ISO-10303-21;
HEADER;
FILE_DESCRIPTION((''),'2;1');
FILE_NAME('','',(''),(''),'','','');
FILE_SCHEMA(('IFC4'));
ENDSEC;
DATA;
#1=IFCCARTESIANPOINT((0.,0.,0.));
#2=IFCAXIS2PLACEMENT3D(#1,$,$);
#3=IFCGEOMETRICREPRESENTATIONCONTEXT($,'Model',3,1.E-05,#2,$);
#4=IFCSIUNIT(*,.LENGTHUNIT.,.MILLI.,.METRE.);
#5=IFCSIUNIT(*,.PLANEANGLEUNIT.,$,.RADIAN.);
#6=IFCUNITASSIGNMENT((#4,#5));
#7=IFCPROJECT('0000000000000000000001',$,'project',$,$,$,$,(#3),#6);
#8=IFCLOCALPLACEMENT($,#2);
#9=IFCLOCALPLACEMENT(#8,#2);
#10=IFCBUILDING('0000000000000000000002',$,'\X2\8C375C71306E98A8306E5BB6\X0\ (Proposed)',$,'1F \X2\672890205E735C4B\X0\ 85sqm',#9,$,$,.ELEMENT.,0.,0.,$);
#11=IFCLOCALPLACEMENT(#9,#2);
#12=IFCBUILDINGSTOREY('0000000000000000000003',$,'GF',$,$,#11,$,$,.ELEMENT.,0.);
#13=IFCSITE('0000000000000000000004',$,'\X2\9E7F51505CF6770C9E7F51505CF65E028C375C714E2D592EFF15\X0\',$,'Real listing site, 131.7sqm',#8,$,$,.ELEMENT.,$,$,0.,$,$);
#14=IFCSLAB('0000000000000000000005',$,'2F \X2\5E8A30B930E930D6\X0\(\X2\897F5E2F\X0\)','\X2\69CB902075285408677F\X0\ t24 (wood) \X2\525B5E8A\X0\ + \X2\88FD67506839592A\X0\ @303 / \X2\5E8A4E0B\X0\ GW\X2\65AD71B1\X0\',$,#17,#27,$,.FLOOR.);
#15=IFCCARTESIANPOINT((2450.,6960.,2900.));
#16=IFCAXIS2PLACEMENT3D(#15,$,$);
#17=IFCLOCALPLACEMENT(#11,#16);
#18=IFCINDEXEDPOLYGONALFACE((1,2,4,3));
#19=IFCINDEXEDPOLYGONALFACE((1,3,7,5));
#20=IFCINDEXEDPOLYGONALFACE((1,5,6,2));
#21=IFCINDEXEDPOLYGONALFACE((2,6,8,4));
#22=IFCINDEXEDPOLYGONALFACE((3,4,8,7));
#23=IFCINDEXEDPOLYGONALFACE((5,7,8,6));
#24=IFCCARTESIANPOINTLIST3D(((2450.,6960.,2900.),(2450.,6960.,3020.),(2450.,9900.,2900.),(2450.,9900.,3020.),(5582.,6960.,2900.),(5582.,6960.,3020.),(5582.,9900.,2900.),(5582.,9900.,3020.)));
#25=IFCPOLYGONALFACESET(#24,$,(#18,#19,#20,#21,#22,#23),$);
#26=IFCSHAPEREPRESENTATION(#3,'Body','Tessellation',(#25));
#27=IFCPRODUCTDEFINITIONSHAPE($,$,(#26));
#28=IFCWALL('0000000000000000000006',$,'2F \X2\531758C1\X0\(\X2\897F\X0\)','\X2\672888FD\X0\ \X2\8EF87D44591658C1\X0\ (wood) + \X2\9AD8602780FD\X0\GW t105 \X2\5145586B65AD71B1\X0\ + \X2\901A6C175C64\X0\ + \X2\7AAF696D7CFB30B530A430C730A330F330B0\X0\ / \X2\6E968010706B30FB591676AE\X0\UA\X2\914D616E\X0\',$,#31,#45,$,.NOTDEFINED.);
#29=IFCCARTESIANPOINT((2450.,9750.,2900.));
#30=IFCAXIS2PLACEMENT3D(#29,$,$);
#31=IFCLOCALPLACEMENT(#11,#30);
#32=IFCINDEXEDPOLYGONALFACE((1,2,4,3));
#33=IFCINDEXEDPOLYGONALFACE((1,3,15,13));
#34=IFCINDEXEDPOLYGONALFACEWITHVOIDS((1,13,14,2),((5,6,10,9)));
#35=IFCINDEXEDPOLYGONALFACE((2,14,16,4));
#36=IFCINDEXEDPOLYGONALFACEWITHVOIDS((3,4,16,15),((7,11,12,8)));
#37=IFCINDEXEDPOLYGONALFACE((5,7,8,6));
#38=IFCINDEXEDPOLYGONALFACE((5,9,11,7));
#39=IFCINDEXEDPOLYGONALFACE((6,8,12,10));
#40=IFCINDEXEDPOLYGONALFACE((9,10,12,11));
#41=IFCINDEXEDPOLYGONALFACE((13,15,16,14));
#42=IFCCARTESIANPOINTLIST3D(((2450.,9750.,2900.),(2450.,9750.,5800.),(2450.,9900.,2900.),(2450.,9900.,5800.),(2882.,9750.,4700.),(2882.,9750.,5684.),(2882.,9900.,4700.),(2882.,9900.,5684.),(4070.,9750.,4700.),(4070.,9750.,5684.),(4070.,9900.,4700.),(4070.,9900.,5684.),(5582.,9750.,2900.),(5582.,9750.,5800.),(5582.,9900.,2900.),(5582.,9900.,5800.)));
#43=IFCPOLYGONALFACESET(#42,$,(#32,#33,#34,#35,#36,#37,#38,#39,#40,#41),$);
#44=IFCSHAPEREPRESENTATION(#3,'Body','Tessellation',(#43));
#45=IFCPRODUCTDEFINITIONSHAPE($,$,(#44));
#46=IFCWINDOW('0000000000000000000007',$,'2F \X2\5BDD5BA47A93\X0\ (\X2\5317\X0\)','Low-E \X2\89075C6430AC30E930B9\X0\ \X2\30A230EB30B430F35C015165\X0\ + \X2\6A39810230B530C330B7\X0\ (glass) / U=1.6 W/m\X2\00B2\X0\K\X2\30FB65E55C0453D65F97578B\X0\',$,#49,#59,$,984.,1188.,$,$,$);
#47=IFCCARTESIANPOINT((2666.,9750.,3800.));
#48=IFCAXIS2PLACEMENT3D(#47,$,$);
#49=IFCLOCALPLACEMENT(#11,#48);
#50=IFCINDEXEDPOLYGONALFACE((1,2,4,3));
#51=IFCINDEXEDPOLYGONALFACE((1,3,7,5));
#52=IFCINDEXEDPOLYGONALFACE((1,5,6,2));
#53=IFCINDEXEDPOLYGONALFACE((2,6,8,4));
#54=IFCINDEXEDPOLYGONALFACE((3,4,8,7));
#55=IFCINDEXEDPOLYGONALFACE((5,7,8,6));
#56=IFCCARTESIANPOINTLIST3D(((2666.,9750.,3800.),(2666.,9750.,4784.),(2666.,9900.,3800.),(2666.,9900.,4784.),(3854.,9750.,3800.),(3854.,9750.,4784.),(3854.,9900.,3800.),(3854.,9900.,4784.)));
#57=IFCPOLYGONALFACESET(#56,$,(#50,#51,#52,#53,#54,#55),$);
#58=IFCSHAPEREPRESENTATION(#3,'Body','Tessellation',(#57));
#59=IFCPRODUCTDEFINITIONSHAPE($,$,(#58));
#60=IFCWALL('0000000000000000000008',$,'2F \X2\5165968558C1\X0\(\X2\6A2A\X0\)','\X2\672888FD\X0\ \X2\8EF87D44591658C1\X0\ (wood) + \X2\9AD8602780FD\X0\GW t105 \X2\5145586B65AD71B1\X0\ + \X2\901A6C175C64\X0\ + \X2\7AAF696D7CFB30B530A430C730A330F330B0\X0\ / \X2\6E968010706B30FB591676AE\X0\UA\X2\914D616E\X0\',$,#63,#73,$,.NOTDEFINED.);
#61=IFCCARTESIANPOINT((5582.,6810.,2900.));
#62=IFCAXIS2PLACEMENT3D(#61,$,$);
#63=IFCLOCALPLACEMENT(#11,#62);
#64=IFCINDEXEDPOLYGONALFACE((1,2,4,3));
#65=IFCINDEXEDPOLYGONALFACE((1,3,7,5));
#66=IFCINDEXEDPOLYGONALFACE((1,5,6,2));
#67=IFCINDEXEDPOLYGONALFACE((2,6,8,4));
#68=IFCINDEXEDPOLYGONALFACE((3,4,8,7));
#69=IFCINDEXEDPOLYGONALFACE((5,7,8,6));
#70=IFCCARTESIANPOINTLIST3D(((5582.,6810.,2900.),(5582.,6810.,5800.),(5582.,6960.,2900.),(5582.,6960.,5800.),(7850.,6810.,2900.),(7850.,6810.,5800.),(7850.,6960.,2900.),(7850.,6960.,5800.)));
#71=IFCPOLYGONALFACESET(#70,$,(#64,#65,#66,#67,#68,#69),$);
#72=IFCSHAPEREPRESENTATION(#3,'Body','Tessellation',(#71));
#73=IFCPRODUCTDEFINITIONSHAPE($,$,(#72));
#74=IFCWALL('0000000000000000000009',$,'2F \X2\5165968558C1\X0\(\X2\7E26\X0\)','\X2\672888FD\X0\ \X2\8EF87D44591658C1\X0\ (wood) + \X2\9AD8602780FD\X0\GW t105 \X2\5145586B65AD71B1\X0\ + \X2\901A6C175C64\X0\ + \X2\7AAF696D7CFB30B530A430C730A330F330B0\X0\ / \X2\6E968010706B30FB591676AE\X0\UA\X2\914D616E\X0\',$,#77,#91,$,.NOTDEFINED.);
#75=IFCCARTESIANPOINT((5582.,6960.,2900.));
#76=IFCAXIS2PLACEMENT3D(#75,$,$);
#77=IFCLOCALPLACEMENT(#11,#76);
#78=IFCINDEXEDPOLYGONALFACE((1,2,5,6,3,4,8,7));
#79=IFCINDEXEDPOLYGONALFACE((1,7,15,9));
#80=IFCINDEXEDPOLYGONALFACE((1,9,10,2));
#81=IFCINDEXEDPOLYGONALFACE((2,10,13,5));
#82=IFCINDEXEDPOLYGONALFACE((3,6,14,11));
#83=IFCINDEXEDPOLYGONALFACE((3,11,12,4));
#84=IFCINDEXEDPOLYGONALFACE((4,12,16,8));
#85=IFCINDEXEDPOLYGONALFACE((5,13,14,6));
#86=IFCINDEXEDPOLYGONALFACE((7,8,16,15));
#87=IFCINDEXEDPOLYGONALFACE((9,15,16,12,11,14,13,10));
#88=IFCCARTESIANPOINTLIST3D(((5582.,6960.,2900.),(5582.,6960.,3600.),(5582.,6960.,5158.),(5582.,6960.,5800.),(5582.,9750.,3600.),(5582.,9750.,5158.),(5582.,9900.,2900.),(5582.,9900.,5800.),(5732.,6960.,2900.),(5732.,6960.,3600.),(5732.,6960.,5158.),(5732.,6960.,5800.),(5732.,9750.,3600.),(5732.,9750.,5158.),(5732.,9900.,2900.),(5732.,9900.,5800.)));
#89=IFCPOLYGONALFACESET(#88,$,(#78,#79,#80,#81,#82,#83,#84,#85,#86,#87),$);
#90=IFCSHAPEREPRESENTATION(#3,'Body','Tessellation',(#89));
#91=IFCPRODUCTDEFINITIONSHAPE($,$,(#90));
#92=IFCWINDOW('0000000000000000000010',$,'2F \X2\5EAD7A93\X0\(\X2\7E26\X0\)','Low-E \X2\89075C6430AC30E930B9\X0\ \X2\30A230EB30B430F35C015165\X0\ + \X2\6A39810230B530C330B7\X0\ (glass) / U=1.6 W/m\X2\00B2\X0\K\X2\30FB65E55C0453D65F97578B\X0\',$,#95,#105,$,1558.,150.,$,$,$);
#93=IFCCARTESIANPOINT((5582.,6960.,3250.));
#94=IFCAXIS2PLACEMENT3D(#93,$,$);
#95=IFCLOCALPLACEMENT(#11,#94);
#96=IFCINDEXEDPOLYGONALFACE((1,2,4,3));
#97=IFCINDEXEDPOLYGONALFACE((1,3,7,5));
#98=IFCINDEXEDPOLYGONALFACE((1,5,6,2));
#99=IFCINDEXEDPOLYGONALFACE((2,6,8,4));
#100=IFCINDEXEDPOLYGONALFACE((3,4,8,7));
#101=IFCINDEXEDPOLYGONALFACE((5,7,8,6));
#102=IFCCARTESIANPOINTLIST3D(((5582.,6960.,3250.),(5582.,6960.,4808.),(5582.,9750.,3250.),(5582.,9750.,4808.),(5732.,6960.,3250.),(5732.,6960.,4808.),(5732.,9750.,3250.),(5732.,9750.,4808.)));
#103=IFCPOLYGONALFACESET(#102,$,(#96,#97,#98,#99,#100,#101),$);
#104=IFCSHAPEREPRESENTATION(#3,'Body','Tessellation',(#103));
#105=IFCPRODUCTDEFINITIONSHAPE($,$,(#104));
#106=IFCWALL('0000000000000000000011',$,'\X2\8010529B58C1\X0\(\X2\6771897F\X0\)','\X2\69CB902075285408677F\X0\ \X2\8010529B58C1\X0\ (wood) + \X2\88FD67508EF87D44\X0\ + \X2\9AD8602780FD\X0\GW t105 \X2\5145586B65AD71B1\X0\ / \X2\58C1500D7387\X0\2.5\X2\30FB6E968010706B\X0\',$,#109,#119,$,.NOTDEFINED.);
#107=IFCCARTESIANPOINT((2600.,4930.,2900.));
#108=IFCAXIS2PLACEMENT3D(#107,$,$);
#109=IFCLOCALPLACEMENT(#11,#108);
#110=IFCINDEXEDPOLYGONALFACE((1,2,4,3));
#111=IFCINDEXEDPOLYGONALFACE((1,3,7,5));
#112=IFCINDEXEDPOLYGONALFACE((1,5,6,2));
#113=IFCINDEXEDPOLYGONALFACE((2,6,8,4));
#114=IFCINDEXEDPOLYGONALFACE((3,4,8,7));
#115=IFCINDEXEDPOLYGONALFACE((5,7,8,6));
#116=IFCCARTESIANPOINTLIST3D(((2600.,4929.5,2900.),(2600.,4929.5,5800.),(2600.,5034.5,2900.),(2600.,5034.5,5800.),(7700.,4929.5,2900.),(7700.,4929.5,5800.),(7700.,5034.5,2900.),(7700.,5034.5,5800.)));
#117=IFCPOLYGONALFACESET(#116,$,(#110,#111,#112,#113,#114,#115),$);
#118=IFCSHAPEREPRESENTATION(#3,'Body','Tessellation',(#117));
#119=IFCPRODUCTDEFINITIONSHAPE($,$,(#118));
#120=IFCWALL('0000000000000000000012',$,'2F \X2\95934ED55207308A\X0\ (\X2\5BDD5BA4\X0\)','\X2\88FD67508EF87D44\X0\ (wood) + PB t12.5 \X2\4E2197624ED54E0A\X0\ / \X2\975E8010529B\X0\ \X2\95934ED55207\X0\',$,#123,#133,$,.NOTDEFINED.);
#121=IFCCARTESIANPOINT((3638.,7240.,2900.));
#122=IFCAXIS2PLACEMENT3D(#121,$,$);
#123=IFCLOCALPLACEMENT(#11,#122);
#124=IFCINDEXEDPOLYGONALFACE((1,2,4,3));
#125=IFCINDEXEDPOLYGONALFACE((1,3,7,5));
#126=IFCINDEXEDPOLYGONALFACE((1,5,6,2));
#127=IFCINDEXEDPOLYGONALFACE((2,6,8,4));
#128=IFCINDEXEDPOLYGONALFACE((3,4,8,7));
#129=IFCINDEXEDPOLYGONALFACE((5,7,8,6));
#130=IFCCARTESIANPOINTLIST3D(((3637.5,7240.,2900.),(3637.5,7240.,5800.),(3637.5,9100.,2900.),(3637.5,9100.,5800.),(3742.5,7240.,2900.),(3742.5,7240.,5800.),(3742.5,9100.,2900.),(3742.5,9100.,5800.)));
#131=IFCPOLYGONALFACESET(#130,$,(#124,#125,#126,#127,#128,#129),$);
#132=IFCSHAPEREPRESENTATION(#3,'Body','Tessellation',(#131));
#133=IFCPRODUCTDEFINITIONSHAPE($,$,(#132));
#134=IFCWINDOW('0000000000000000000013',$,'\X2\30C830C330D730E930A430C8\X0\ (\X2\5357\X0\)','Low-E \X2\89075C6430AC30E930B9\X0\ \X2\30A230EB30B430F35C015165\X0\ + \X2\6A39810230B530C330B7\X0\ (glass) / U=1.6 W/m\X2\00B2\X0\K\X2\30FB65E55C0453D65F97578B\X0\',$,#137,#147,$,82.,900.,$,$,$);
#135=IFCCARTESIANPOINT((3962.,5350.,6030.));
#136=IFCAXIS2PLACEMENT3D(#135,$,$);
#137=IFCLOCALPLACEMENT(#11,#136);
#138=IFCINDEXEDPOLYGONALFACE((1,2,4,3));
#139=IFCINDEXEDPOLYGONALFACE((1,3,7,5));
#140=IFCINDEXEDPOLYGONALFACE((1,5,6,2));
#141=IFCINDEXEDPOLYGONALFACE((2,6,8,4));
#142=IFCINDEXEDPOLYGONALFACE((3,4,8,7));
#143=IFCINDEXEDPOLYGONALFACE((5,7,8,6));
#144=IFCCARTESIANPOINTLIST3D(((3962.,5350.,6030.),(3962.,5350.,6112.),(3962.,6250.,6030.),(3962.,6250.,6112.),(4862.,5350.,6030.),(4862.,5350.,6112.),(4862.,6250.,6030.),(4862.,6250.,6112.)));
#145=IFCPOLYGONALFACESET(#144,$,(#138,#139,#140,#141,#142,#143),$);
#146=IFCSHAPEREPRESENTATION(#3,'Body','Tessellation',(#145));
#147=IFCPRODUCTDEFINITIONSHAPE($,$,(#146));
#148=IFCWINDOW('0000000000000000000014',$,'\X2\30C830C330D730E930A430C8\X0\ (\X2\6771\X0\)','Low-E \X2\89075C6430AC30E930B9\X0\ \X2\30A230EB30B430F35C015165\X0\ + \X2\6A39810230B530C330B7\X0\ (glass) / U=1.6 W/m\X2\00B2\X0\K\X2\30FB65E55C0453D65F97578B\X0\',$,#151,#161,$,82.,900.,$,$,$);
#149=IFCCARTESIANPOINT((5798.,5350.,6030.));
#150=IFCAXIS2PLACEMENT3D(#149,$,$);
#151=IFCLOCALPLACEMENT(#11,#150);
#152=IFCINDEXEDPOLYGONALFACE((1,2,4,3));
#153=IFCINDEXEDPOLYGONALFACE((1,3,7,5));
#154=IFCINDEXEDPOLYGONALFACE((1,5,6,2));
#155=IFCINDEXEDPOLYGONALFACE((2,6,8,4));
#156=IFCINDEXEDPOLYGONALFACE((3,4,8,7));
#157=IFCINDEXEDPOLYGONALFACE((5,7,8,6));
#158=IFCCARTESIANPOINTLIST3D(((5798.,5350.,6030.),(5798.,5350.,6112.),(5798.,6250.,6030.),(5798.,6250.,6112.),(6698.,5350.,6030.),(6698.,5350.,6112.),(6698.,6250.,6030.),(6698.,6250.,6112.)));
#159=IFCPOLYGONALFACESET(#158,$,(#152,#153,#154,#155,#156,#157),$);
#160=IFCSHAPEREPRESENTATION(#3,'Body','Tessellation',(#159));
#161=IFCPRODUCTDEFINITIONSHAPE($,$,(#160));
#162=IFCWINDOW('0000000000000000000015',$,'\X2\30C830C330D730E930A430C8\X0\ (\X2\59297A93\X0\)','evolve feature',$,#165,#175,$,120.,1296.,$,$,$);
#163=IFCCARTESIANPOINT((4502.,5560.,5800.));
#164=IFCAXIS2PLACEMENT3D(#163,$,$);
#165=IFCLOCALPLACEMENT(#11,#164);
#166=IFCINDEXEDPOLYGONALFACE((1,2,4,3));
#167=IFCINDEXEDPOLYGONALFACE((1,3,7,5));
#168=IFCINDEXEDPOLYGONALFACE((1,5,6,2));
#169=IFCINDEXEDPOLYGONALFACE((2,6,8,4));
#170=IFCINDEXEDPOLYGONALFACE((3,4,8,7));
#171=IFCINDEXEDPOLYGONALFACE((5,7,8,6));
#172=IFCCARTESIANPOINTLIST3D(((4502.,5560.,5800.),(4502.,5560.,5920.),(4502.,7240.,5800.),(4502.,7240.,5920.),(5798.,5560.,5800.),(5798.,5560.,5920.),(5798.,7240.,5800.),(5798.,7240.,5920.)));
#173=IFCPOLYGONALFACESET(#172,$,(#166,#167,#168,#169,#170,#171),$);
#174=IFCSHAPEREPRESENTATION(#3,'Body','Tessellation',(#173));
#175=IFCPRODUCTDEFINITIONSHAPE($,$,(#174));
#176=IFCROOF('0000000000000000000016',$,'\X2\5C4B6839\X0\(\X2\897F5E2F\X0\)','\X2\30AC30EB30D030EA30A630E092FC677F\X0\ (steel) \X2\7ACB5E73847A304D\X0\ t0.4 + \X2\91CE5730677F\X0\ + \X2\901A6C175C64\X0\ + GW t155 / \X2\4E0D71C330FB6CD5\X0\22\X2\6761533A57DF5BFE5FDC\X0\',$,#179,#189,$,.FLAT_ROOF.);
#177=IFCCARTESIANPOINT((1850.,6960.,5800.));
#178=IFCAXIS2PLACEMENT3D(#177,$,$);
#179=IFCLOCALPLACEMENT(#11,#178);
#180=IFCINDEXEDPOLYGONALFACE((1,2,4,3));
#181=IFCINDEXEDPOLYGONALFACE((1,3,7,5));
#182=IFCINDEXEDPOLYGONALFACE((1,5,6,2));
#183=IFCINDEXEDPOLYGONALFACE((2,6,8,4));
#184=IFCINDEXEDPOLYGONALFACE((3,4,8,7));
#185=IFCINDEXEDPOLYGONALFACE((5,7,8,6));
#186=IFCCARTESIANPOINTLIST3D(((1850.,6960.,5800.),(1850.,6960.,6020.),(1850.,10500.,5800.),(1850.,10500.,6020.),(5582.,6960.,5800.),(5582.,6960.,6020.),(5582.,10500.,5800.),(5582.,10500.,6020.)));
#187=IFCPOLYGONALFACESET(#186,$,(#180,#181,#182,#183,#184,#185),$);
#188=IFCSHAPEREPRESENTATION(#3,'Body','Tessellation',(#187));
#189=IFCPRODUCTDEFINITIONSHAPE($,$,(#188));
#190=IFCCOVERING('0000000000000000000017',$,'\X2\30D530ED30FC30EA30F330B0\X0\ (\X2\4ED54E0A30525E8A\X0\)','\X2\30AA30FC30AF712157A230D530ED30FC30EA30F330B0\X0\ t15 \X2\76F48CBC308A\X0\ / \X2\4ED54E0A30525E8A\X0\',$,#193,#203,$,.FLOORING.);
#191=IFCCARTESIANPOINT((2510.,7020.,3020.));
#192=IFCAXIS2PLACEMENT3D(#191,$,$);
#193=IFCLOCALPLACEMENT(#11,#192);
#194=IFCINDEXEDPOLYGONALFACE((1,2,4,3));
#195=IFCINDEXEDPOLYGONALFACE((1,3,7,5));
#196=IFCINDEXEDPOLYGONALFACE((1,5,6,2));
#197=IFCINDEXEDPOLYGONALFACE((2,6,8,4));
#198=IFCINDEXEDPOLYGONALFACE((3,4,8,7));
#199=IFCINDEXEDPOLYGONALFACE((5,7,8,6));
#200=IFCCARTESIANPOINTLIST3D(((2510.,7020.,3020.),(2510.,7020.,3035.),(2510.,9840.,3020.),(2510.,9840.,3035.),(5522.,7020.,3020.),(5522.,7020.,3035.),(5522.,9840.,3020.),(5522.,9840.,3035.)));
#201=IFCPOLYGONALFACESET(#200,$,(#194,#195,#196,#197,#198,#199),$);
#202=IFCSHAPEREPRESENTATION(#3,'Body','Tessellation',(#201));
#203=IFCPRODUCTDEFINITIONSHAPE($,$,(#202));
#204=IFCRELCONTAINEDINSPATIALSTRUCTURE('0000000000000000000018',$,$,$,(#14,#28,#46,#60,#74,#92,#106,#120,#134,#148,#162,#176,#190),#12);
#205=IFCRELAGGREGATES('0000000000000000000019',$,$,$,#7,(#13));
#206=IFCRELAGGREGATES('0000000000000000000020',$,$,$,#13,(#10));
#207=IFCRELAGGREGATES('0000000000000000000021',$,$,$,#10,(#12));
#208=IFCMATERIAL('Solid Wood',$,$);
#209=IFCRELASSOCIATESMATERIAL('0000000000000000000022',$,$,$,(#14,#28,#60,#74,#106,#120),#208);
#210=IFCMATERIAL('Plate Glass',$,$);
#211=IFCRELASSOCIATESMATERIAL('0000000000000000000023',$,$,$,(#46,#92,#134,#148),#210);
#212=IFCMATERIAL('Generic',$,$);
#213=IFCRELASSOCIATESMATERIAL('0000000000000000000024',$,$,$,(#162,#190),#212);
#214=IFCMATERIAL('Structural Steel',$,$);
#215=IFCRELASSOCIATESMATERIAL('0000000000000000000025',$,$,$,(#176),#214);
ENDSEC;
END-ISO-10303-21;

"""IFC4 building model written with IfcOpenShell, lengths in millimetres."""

from ifc_helpers import new_model, si_unit, frame, frame_2d, origin, place, context, project, spatial, rectangle, extrude, material, element, fill, save


model = new_model("IFC4")

# Units and contexts
model_context = context("Model", 3, precision=1e-05, world=origin())
ifc_project = project(units=[si_unit("LENGTHUNIT", "METRE", prefix="MILLI"), si_unit("PLANEANGLEUNIT", "RADIAN")], contexts=[model_context])

# Site, building, storey
site_placement = place(None, origin())
site = spatial("IfcSite", under=ifc_project, at=site_placement, Name="鹿児島県鹿児島市谷山中央５", ObjectType="Real listing site, 131.7sqm", CompositionType="ELEMENT", RefElevation=0.0)
building_placement = place(site_placement, origin())
building = spatial("IfcBuilding", under=site, at=building_placement, Name="谷山の風の家 (Proposed)", ObjectType="1F 木造平屋 85sqm", CompositionType="ELEMENT", ElevationOfRefHeight=0.0, ElevationOfTerrain=0.0)
storey_placement = place(building_placement, origin())
storey = spatial("IfcBuildingStorey", under=building, at=storey_placement, Name="GF", CompositionType="ELEMENT", Elevation=0.0)

# Slab
ifc_material_1 = material(Name="Solid Wood")
slab_placement = place(storey_placement, frame((2450.0, 6960.0, 2900.0)))
element("IfcSlab", 1, at=slab_placement, inside=storey, material=ifc_material_1, Name="2F 床スラブ(西帯)", Description="構造用合板 t24 (wood) 剛床 + 製材根太 @303 / 床下 GW断熱", PredefinedType="FLOOR", context=model_context, shape_type="SweptSolid", body=[
    extrude(rectangle(XDim=3132.0, YDim=2940.0, at=frame_2d((1566.0, 1470.0))), frame((2450.0, 6960.0, 2900.0)), (0.0, 0.0, 1.0), 120.0),
])

# Wall, opening, window
wall_1_placement = place(storey_placement, frame((2450.0, 9750.0, 2900.0)))
wall_1 = element("IfcWall", 2, at=wall_1_placement, inside=storey, material=ifc_material_1, Name="2F 北壁(西)", Description="木製 軸組外壁 (wood) + 高性能GW t105 充填断熱 + 通気層 + 窯業系サイディング / 準耐火・外皮UA配慮", PredefinedType="NOTDEFINED", context=model_context, shape_type="SweptSolid", body=[
    extrude(rectangle(XDim=3132.0, YDim=150.0, at=frame_2d((1566.0, 75.0))), frame((2450.0, 9750.0, 2900.0)), (0.0, 0.0, 1.0), 2900.0),
])
opening_1_placement = place(storey_placement, frame((2666.0, 9750.0, 3800.0)))
opening_1 = element("IfcOpeningElement", 3, at=opening_1_placement, cuts=wall_1, PredefinedType="NOTDEFINED", context=model_context, shape_type="SweptSolid", body=[
    extrude(rectangle(XDim=1188.0, YDim=150.0, at=frame_2d((594.0, 75.0))), frame((2666.0, 9750.0, 3800.0)), (0.0, 0.0, 1.0), 984.0),
])
ifc_material_2 = material(Name="Plate Glass")
window_1_placement = place(storey_placement, frame((2666.0, 9750.0, 3800.0)))
window_1 = element("IfcWindow", 4, at=window_1_placement, inside=storey, material=ifc_material_2, Name="2F 寝室窓 (北)", Description="Low-E 複層ガラス アルゴン封入 + 樹脂サッシ (glass) / U=1.6 W/m²K・日射取得型", OverallHeight=984.0, OverallWidth=1188.0, context=model_context, shape_type="SweptSolid", body=[
    extrude(rectangle(XDim=1188.0, YDim=150.0, at=frame_2d((594.0, 75.0))), frame((2666.0, 9750.0, 3800.0)), (0.0, 0.0, 1.0), 984.0),
])
fill(opening_1, window_1)

# Wall
wall_2_placement = place(storey_placement, frame((5582.0, 6810.0, 2900.0)))
element("IfcWall", 5, at=wall_2_placement, inside=storey, material=ifc_material_1, Name="2F 入隅壁(横)", Description="木製 軸組外壁 (wood) + 高性能GW t105 充填断熱 + 通気層 + 窯業系サイディング / 準耐火・外皮UA配慮", PredefinedType="NOTDEFINED", context=model_context, shape_type="SweptSolid", body=[
    extrude(rectangle(XDim=2268.0, YDim=150.0, at=frame_2d((1134.0, 75.0))), frame((5582.0, 6810.0, 2900.0)), (0.0, 0.0, 1.0), 2900.0),
])

# Wall, opening, window
wall_3_placement = place(storey_placement, frame((5582.0, 6960.0, 2900.0)))
wall_3 = element("IfcWall", 6, at=wall_3_placement, inside=storey, material=ifc_material_1, Name="2F 入隅壁(縦)", Description="木製 軸組外壁 (wood) + 高性能GW t105 充填断熱 + 通気層 + 窯業系サイディング / 準耐火・外皮UA配慮", PredefinedType="NOTDEFINED", context=model_context, shape_type="SweptSolid", body=[
    extrude(rectangle(XDim=150.0, YDim=2940.0, at=frame_2d((75.0, 1470.0))), frame((5582.0, 6960.0, 2900.0)), (0.0, 0.0, 1.0), 2900.0),
])
opening_2_placement = place(storey_placement, frame((5582.0, 6960.0, 3250.0)))
opening_2 = element("IfcOpeningElement", 7, at=opening_2_placement, cuts=wall_3, PredefinedType="NOTDEFINED", context=model_context, shape_type="SweptSolid", body=[
    extrude(rectangle(XDim=150.0, YDim=2790.0, at=frame_2d((75.0, 1395.0))), frame((5582.0, 6960.0, 3250.0)), (0.0, 0.0, 1.0), 1558.0),
])
window_2_placement = place(storey_placement, frame((5582.0, 6960.0, 3250.0)))
window_2 = element("IfcWindow", 8, at=window_2_placement, inside=storey, material=ifc_material_2, Name="2F 庭窓(縦)", Description="Low-E 複層ガラス アルゴン封入 + 樹脂サッシ (glass) / U=1.6 W/m²K・日射取得型", OverallHeight=1558.0, OverallWidth=150.0, context=model_context, shape_type="SweptSolid", body=[
    extrude(rectangle(XDim=150.0, YDim=2790.0, at=frame_2d((75.0, 1395.0))), frame((5582.0, 6960.0, 3250.0)), (0.0, 0.0, 1.0), 1558.0),
])
fill(opening_2, window_2)

# Walls
wall_4_placement = place(storey_placement, frame((2600.0, 4930.0, 2900.0)))
element("IfcWall", 9, at=wall_4_placement, inside=storey, material=ifc_material_1, Name="耐力壁(東西)", Description="構造用合板 耐力壁 (wood) + 製材軸組 + 高性能GW t105 充填断熱 / 壁倍率2.5・準耐火", PredefinedType="NOTDEFINED", context=model_context, shape_type="SweptSolid", body=[
    extrude(rectangle(XDim=5100.0, YDim=105.0, at=frame_2d((2550.0, 52.0))), frame((2600.0, 4930.0, 2900.0)), (0.0, 0.0, 1.0), 2900.0),
])
wall_5_placement = place(storey_placement, frame((3638.0, 7240.0, 2900.0)))
element("IfcWall", 10, at=wall_5_placement, inside=storey, material=ifc_material_1, Name="2F 間仕切り (寝室)", Description="製材軸組 (wood) + PB t12.5 両面仕上 / 非耐力 間仕切", PredefinedType="NOTDEFINED", context=model_context, shape_type="SweptSolid", body=[
    extrude(rectangle(XDim=105.0, YDim=1860.0, at=frame_2d((52.0, 930.0))), frame((3638.0, 7240.0, 2900.0)), (0.0, 0.0, 1.0), 2900.0),
])

# Windows
window_3_placement = place(storey_placement, frame((3962.0, 5350.0, 6030.0)))
element("IfcWindow", 11, at=window_3_placement, inside=storey, material=ifc_material_2, Name="トップライト (南)", Description="Low-E 複層ガラス アルゴン封入 + 樹脂サッシ (glass) / U=1.6 W/m²K・日射取得型", OverallHeight=82.0, OverallWidth=900.0, context=model_context, shape_type="SweptSolid", body=[
    extrude(rectangle(XDim=900.0, YDim=900.0, at=frame_2d((450.0, 450.0))), frame((3962.0, 5350.0, 6030.0)), (0.0, 0.0, 1.0), 82.0),
])
window_4_placement = place(storey_placement, frame((5798.0, 5350.0, 6030.0)))
element("IfcWindow", 12, at=window_4_placement, inside=storey, material=ifc_material_2, Name="トップライト (東)", Description="Low-E 複層ガラス アルゴン封入 + 樹脂サッシ (glass) / U=1.6 W/m²K・日射取得型", OverallHeight=82.0, OverallWidth=900.0, context=model_context, shape_type="SweptSolid", body=[
    extrude(rectangle(XDim=900.0, YDim=900.0, at=frame_2d((450.0, 450.0))), frame((5798.0, 5350.0, 6030.0)), (0.0, 0.0, 1.0), 82.0),
])
ifc_material_3 = material(Name="Generic")
window_5_placement = place(storey_placement, frame((4502.0, 5560.0, 5800.0)))
element("IfcWindow", 13, at=window_5_placement, inside=storey, material=ifc_material_3, Name="トップライト (天窓)", Description="evolve feature", OverallHeight=120.0, OverallWidth=1296.0, context=model_context, shape_type="SweptSolid", body=[
    extrude(rectangle(XDim=1296.0, YDim=1680.0, at=frame_2d((648.0, 840.0))), frame((4502.0, 5560.0, 5800.0)), (0.0, 0.0, 1.0), 120.0),
])

# Roof
ifc_material_4 = material(Name="Structural Steel")
for number, where, name in (
    (14, (1850.0, 6960.0, 5800.0), "屋根(西帯)"),
):
    element("IfcRoof", number, at=place(storey_placement, frame(where)), inside=storey, material=ifc_material_4, Name=name, Description="ガルバリウム鋼板 (steel) 立平葺き t0.4 + 野地板 + 通気層 + GW t155 / 不燃・法22条区域対応", PredefinedType="FLAT_ROOF", context=model_context, shape_type="SweptSolid", body=[
        extrude(rectangle(XDim=3732.0, YDim=3540.0, at=frame_2d((1866.0, 1770.0))), frame((1850.0, 6960.0, 5800.0)), (0.0, 0.0, 1.0), 220.0),
    ])

# Covering
covering_placement = place(storey_placement, frame((2510.0, 7020.0, 3020.0)))
element("IfcCovering", 15, at=covering_placement, inside=storey, material=ifc_material_3, Name="フローリング (仕上げ床)", Description="オーク無垢フローリング t15 直貼り / 仕上げ床", PredefinedType="FLOORING", context=model_context, shape_type="SweptSolid", body=[
    extrude(rectangle(XDim=3012.0, YDim=2820.0, at=frame_2d((1506.0, 1410.0))), frame((2510.0, 7020.0, 3020.0)), (0.0, 0.0, 1.0), 15.0),
])

save(model, "model.ifc")
